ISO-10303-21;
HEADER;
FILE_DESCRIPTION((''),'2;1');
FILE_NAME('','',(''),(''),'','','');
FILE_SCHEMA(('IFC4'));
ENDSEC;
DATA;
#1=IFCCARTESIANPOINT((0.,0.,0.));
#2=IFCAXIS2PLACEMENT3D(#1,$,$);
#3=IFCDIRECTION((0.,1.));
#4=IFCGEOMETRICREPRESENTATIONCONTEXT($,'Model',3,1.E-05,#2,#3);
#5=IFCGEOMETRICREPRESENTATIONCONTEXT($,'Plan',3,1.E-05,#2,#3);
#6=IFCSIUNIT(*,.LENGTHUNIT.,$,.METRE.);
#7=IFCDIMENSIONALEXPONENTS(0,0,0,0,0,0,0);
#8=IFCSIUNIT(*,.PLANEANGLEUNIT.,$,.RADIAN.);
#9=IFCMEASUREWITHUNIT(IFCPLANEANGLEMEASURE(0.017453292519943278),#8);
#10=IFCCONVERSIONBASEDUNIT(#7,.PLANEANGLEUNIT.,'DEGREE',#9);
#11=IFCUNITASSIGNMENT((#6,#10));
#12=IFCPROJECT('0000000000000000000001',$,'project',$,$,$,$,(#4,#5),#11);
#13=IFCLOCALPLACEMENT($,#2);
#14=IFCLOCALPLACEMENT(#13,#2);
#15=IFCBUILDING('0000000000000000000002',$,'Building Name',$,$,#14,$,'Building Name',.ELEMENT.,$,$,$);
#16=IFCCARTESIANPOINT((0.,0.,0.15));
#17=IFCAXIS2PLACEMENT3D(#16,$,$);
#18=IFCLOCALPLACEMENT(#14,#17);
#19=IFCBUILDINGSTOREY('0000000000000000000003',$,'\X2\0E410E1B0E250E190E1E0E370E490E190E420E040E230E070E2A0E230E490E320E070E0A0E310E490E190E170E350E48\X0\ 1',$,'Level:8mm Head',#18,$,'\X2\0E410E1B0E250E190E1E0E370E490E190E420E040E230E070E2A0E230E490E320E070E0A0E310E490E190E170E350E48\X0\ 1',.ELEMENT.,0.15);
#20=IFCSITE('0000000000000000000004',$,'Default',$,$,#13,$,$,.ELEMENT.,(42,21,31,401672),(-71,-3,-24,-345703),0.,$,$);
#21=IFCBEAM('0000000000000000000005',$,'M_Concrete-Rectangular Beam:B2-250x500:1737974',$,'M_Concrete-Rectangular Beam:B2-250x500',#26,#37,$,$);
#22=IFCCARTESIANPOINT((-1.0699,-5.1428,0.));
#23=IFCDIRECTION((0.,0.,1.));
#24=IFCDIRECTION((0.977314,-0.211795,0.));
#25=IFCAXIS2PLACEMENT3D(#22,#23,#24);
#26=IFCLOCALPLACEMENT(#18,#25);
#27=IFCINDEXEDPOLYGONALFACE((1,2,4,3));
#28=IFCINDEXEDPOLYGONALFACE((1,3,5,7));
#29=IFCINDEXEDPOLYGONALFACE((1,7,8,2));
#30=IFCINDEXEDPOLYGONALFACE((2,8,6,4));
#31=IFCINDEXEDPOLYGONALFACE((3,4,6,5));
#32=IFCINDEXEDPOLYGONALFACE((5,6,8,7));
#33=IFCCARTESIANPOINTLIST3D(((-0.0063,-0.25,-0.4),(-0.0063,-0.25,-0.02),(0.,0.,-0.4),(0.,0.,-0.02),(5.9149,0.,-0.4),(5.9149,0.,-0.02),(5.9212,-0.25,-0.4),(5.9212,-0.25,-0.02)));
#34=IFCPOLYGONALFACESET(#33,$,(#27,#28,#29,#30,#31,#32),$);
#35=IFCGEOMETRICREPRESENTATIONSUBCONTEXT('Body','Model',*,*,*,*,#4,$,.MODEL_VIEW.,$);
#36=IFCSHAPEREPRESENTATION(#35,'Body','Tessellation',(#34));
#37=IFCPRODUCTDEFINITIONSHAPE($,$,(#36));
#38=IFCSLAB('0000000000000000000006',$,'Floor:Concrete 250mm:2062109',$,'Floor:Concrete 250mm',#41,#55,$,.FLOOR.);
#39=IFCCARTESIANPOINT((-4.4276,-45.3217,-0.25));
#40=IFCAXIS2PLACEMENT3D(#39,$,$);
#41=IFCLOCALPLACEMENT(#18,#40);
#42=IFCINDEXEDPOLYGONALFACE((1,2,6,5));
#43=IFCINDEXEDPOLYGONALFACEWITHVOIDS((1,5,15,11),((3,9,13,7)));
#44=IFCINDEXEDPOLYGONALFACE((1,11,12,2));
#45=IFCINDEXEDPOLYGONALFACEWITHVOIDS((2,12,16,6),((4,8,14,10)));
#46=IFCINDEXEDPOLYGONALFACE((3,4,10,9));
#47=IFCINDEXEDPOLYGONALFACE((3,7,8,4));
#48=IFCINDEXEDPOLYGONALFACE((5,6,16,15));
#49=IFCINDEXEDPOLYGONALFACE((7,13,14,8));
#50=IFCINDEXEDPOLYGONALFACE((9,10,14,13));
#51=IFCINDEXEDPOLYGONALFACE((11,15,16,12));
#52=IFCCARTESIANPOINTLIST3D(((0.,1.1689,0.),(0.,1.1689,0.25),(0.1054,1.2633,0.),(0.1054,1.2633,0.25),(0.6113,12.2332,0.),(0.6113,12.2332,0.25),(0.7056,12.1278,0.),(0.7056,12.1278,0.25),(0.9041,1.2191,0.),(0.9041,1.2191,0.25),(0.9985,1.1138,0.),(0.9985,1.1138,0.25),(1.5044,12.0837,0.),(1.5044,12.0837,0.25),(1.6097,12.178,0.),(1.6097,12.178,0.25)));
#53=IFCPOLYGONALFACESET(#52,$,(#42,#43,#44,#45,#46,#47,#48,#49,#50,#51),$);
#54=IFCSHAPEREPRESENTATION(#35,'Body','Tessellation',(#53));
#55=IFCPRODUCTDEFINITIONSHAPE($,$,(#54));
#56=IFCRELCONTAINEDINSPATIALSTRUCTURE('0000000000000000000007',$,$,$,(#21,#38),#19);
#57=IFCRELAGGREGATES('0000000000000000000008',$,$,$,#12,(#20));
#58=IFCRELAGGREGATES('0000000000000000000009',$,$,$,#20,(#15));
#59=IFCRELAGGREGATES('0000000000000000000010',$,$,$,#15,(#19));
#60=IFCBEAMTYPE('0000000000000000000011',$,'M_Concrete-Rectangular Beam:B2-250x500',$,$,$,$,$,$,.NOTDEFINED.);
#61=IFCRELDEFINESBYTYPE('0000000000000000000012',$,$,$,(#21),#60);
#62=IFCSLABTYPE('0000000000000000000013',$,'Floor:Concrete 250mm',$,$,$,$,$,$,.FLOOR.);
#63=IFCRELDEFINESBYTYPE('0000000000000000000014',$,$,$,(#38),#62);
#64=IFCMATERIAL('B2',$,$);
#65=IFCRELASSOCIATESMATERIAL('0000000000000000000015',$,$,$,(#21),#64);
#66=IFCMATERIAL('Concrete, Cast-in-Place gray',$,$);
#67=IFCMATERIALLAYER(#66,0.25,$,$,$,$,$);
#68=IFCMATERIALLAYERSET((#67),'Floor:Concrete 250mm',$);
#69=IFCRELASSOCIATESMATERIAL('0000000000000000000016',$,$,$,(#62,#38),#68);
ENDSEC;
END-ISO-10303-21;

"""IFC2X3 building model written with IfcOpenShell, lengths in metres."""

from ifc_helpers import new_model, entity, si_unit, converted_unit, direction, frame, frame_2d, origin, origin_2d_with_axis, place, context, subcontext, project, spatial, rectangle, extrude, clip, halfspace, material, layer, layer_set, layer_usage, type_object, element, save


model = new_model("IFC2X3")

# Units and contexts
model_context = context("Model", 3, precision=1e-05, world=origin(), true_north=direction((0.0, 1.0)))
plan_context = context("Plan", 3, precision=1e-05, world=origin(), true_north=direction((0.0, 1.0)))
body_context = subcontext(model_context, "Body", "Model", "MODEL_VIEW")
ifc_project = project(units=[si_unit("LENGTHUNIT", "METRE"), converted_unit("PLANEANGLEUNIT", "DEGREE", entity("IfcPlaneAngleMeasure", 0.017453292519943278), si_unit("PLANEANGLEUNIT", "RADIAN"), dimensions=[0, 0, 0, 0, 0, 0, 0])], contexts=[model_context, plan_context])

# Site, building, storey
site_placement = place(None, origin())
site = spatial("IfcSite", under=ifc_project, at=site_placement, Name="Default", CompositionType="ELEMENT", RefLatitude=(42, 21, 31, 401672), RefLongitude=(-71, -3, -24, -345703), RefElevation=0.0)
building_placement = place(site_placement, origin())
building = spatial("IfcBuilding", under=site, at=building_placement, Name="Building Name", LongName="Building Name", CompositionType="ELEMENT")
storey_placement = place(building_placement, frame((0.0, 0.0, 0.15)))
storey = spatial("IfcBuildingStorey", under=building, at=storey_placement, Name="แปลนพื้นโครงสร้างชั้นที่ 1", ObjectType="Level:8mm Head", LongName="แปลนพื้นโครงสร้างชั้นที่ 1", CompositionType="ELEMENT", Elevation=0.15)

# Beam
ifc_material_1 = material(Name="B2")
beam_type_1 = type_object("IfcBeamType", Name="M_Concrete-Rectangular Beam:B2-250x500", PredefinedType="NOTDEFINED")
beam_1_placement = place(storey_placement, frame((-1.0699, -5.1428, 0.0), z_axis=(0.0, 0.0, 1.0), x_axis=(0.977314, -0.211795, 0.0)))
element("IfcBeam", 1, at=beam_1_placement, inside=storey, type_object=beam_type_1, material=ifc_material_1, Name="M_Concrete-Rectangular Beam:B2-250x500:1737974", ObjectType="M_Concrete-Rectangular Beam:B2-250x500", context=body_context, shape_type="Clipping", body=[
    clip(clip(extrude(rectangle(XDim=0.38, YDim=0.25, at=origin_2d_with_axis()), frame((-0.0063, -0.125, -0.21), z_axis=(1.0, 0.0, 0.0), x_axis=(0.0, 0.0, -1.0)), (0.0, 0.0, 1.0), 5.9274), halfspace(frame((-0.0125, -0.4998, 5.1), z_axis=(-0.999686, 0.02504, 0.0), x_axis=(0.0, 0.0, -1.0)), False)), halfspace(frame((5.9149, 0.0, 5.1), z_axis=(0.999686, 0.02504, 0.0), x_axis=(0.0, 0.0, -1.0)), False)),
])

# Shared definitions
ifc_material_2 = material(Name="Concrete, Cast-in-Place gray")
ifc_layer_1 = layer(ifc_material_2, 0.25)
ifc_layer_set_1 = layer_set([ifc_layer_1], Name="Floor:Concrete 250mm")
slab_type_1 = type_object("IfcSlabType", Name="Floor:Concrete 250mm", PredefinedType="FLOOR", material=ifc_layer_set_1)

# Slab, opening
ifc_layer_usage_1 = layer_usage(ifc_layer_set_1, "AXIS3", "POSITIVE", 0.0)
slab_1_placement = place(storey_placement, frame((-4.4276, -45.3217, -0.25)))
slab_1 = element("IfcSlab", 2, at=slab_1_placement, inside=storey, type_object=slab_type_1, material=ifc_layer_usage_1, Name="Floor:Concrete 250mm:2062109", ObjectType="Floor:Concrete 250mm", PredefinedType="FLOOR", context=body_context, shape_type="SweptSolid", body=[
    extrude(rectangle(XDim=11.0811, YDim=1.0, at=frame_2d((12.546, 0.6931), x_axis=(0.055162, -0.998477))), frame((13.3508, 5.9804, 0.25), z_axis=(0.0, 0.0, -1.0), x_axis=(-1.0, 0.0, 0.0)), (0.0, 0.0, 1.0), 0.25),
])
opening_1_placement = place(slab_1_placement, frame((0.8049, 6.6735, 0.25)))
element("IfcOpeningElement", 3, at=opening_1_placement, cuts=slab_1, ObjectType="Opening", context=body_context, shape_type="SweptSolid", body=[
    extrude(rectangle(XDim=10.8811, YDim=0.8, at=origin_2d_with_axis()), frame((0.0, 0.0, 0.0), z_axis=(0.0, 0.0, -1.0), x_axis=(0.055162, 0.998477, 0.0)), (0.0, 0.0, 1.0), 0.25),
])

save(model, "model.ifc")
